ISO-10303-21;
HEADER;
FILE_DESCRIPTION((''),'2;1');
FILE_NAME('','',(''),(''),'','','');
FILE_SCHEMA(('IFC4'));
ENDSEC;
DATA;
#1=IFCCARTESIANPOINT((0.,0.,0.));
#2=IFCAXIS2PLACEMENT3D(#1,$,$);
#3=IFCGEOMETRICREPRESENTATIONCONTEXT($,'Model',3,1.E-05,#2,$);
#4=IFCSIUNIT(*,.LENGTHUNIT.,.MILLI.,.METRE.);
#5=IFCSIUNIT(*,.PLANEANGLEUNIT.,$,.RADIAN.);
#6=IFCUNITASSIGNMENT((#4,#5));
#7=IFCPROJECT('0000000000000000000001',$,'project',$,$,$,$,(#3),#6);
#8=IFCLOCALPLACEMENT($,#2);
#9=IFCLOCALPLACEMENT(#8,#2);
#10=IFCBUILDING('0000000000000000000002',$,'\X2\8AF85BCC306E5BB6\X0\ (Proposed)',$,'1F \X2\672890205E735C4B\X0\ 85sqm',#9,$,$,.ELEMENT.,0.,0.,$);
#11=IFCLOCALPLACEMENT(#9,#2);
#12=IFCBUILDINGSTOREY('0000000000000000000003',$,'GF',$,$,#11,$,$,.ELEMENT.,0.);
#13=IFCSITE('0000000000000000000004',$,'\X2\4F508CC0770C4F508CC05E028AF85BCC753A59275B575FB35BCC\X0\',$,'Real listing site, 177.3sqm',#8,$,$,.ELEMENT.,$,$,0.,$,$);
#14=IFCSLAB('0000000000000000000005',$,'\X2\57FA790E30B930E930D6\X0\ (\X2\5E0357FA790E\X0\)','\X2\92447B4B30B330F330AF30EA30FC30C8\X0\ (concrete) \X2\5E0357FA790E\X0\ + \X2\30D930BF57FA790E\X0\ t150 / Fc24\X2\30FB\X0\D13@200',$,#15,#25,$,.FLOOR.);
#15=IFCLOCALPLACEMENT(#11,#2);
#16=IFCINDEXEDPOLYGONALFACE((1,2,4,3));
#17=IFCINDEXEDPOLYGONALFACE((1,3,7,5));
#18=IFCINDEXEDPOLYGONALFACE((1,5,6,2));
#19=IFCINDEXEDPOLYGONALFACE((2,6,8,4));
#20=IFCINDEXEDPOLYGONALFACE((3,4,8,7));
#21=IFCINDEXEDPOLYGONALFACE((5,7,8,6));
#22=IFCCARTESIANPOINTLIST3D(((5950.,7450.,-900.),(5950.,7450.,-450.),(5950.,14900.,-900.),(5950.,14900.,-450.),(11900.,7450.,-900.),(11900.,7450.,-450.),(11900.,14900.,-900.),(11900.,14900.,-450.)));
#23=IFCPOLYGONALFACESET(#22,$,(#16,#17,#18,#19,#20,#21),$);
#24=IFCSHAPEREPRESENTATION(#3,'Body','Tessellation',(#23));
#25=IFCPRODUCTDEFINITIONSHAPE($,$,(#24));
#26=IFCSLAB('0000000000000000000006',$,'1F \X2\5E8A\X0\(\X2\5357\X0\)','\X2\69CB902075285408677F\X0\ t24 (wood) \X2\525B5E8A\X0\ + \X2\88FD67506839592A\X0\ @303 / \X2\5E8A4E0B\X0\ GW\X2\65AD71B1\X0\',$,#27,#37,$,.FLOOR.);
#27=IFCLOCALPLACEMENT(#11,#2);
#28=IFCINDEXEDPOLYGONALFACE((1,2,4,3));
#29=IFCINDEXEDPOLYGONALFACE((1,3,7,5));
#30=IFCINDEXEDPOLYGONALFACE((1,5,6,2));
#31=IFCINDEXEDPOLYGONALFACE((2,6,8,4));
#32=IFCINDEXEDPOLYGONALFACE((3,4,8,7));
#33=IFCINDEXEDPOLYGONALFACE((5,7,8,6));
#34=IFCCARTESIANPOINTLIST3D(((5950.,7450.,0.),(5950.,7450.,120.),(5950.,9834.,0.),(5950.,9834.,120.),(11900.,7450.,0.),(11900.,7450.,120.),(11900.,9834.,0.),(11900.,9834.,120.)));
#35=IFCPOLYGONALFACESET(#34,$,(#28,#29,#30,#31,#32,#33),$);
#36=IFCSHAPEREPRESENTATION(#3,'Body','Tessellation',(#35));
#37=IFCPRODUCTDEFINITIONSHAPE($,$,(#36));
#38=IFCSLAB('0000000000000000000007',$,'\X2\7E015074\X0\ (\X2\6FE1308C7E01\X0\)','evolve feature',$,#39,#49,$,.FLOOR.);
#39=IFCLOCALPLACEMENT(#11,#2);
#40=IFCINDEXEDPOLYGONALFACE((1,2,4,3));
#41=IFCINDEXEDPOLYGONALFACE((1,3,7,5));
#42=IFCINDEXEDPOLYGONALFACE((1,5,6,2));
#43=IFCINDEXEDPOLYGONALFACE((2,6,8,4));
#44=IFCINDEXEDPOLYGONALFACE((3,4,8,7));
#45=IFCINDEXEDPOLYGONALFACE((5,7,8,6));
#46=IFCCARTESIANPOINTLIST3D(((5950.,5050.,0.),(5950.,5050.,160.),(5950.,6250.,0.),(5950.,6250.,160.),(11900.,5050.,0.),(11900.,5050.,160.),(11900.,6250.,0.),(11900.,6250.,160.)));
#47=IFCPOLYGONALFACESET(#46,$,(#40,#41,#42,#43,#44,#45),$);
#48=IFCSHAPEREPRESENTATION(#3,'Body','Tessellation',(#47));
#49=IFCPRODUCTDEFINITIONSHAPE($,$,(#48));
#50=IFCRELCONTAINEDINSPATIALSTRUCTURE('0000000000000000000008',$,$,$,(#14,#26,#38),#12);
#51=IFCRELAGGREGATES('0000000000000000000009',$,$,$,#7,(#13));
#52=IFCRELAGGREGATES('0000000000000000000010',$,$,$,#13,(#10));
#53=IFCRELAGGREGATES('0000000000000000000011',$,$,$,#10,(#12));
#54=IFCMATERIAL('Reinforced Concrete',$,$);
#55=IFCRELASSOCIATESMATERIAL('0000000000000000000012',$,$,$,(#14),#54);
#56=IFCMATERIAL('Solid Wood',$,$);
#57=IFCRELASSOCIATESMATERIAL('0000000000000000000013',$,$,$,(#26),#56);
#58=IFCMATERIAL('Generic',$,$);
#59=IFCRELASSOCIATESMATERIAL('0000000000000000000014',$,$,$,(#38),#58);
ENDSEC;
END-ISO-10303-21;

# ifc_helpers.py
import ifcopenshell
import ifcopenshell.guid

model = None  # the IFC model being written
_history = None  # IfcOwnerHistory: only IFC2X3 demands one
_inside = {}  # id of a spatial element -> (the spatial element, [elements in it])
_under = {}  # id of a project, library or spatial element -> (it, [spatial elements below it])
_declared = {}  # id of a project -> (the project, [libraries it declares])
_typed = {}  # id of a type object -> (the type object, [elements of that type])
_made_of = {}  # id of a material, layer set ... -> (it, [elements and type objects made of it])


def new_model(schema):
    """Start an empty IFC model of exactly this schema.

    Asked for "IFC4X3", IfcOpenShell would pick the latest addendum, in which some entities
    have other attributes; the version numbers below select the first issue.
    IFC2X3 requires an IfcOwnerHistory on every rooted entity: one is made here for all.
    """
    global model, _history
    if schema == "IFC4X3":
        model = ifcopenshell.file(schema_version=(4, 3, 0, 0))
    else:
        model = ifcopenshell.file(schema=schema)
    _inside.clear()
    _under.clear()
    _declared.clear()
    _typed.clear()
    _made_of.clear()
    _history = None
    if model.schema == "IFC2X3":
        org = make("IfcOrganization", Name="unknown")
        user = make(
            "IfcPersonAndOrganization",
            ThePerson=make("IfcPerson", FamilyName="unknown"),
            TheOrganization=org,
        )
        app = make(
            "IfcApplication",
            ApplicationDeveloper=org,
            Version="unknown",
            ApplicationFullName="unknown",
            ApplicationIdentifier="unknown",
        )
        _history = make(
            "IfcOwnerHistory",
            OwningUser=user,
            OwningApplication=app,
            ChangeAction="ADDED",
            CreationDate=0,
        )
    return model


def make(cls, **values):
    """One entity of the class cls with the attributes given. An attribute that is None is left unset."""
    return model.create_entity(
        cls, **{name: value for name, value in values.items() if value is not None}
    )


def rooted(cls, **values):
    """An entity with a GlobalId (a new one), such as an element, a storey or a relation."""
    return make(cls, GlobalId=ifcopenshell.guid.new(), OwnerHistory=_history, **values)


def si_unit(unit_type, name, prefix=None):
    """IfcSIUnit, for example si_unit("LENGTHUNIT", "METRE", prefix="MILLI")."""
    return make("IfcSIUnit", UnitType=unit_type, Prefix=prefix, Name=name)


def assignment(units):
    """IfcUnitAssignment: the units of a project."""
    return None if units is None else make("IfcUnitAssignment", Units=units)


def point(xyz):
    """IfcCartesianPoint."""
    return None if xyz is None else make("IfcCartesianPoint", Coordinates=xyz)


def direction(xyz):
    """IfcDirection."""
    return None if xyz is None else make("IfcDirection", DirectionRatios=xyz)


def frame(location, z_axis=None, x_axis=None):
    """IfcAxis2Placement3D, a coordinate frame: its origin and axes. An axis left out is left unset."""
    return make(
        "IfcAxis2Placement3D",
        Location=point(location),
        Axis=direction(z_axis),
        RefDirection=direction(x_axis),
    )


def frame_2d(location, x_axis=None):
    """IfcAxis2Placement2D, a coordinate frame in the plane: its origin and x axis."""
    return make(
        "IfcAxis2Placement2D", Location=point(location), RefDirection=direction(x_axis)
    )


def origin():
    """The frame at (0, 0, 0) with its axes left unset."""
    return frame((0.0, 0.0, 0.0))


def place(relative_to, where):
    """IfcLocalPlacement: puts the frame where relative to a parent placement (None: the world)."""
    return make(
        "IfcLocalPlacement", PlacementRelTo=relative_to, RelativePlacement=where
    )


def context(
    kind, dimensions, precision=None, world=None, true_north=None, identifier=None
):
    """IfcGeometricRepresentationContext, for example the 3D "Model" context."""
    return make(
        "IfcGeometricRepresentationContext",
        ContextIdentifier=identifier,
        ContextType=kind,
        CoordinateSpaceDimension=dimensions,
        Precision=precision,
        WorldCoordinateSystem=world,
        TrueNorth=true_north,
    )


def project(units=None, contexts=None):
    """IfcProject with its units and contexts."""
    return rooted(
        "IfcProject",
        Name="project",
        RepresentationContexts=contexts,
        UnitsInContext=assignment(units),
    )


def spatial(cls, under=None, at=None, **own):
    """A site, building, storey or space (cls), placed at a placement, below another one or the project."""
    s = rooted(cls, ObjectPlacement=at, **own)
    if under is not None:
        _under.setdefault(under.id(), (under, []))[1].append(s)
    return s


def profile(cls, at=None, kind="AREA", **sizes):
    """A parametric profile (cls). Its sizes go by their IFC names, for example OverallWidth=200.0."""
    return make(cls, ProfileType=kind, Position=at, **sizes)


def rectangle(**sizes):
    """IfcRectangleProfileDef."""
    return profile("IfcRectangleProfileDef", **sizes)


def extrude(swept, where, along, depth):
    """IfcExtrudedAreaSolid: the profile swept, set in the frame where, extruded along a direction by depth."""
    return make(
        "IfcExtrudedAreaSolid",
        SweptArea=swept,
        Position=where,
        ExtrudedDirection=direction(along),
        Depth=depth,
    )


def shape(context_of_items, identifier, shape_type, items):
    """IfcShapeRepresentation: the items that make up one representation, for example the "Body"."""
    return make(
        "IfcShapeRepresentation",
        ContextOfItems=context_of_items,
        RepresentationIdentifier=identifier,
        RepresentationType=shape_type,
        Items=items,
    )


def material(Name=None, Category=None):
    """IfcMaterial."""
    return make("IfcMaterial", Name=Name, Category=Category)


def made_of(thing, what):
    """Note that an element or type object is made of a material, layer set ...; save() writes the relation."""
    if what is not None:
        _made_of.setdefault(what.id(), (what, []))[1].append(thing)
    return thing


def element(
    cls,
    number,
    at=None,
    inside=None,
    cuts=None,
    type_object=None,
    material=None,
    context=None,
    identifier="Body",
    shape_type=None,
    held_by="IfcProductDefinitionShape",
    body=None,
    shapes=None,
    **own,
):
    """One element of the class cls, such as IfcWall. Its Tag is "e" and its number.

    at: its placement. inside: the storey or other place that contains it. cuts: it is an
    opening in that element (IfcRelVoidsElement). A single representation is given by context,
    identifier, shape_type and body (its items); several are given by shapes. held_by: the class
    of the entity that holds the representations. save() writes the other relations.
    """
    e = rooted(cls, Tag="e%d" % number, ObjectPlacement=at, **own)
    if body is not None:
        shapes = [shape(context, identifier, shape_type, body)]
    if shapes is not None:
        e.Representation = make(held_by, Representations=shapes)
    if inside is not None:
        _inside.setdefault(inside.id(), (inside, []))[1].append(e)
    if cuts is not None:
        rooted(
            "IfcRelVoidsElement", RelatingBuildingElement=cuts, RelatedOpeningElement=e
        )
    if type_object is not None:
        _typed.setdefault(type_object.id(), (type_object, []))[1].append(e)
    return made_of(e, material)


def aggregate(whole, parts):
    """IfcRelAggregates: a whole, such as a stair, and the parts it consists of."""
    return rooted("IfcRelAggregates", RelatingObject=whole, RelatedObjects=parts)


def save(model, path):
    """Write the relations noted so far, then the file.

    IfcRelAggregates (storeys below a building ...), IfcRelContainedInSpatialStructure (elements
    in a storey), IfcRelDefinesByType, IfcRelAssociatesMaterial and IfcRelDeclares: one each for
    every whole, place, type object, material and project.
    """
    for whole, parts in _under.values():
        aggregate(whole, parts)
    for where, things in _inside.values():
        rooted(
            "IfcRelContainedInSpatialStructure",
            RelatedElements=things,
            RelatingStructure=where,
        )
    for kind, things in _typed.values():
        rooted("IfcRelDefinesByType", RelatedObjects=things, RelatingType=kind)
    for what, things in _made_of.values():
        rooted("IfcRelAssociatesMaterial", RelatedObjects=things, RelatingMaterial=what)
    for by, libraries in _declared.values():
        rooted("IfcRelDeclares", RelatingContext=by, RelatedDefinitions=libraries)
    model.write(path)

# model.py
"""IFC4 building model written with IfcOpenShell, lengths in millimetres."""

from ifc_helpers import new_model, si_unit, frame, frame_2d, origin, place, context, project, spatial, rectangle, extrude, material, element, save


model = new_model("IFC4")

# Units and contexts
model_context = context("Model", 3, precision=1e-05, world=origin())
ifc_project = project(units=[si_unit("LENGTHUNIT", "METRE", prefix="MILLI"), si_unit("PLANEANGLEUNIT", "RADIAN")], contexts=[model_context])

# Site, building, storey
site_placement = place(None, origin())
site = spatial("IfcSite", under=ifc_project, at=site_placement, Name="佐賀県佐賀市諸富町大字徳富", ObjectType="Real listing site, 177.3sqm", CompositionType="ELEMENT", RefElevation=0.0)
building_placement = place(site_placement, origin())
building = spatial("IfcBuilding", under=site, at=building_placement, Name="諸富の家 (Proposed)", ObjectType="1F 木造平屋 85sqm", CompositionType="ELEMENT", ElevationOfRefHeight=0.0, ElevationOfTerrain=0.0)
storey_placement = place(building_placement, origin())
storey = spatial("IfcBuildingStorey", under=building, at=storey_placement, Name="GF", CompositionType="ELEMENT", Elevation=0.0)

# Slabs
ifc_material_1 = material(Name="Reinforced Concrete")
slab_1_placement = place(storey_placement, frame((2975.0, 3725.0, -450.0)))
element("IfcSlab", 1, at=slab_1_placement, inside=storey, material=ifc_material_1, Name="基礎スラブ (布基礎)", Description="鉄筋コンクリート (concrete) 布基礎 + ベタ基礎 t150 / Fc24・D13@200", PredefinedType="FLOOR", context=model_context, shape_type="SweptSolid", body=[
    extrude(rectangle(XDim=5950.0, YDim=7450.0, at=frame_2d((2975.0, 3725.0))), frame((2975.0, 3725.0, -450.0)), (0.0, 0.0, 1.0), 450.0),
])
ifc_material_2 = material(Name="Solid Wood")
slab_2_placement = place(storey_placement, frame((2975.0, 3725.0, 0.0)))
element("IfcSlab", 2, at=slab_2_placement, inside=storey, material=ifc_material_2, Name="1F 床(南)", Description="構造用合板 t24 (wood) 剛床 + 製材根太 @303 / 床下 GW断熱", PredefinedType="FLOOR", context=model_context, shape_type="SweptSolid", body=[
    extrude(rectangle(XDim=5950.0, YDim=2384.0, at=frame_2d((2975.0, 1192.0))), frame((2975.0, 3725.0, 0.0)), (0.0, 0.0, 1.0), 120.0),
])
ifc_material_3 = material(Name="Generic")
slab_3_placement = place(storey_placement, frame((2975.0, 2525.0, 0.0)))
element("IfcSlab", 3, at=slab_3_placement, inside=storey, material=ifc_material_3, Name="縁側 (濡れ縁)", Description="evolve feature", PredefinedType="FLOOR", context=model_context, shape_type="SweptSolid", body=[
    extrude(rectangle(XDim=5950.0, YDim=1200.0, at=frame_2d((2975.0, 600.0))), frame((2975.0, 2525.0, 0.0)), (0.0, 0.0, 1.0), 160.0),
])

save(model, "model.ifc")
